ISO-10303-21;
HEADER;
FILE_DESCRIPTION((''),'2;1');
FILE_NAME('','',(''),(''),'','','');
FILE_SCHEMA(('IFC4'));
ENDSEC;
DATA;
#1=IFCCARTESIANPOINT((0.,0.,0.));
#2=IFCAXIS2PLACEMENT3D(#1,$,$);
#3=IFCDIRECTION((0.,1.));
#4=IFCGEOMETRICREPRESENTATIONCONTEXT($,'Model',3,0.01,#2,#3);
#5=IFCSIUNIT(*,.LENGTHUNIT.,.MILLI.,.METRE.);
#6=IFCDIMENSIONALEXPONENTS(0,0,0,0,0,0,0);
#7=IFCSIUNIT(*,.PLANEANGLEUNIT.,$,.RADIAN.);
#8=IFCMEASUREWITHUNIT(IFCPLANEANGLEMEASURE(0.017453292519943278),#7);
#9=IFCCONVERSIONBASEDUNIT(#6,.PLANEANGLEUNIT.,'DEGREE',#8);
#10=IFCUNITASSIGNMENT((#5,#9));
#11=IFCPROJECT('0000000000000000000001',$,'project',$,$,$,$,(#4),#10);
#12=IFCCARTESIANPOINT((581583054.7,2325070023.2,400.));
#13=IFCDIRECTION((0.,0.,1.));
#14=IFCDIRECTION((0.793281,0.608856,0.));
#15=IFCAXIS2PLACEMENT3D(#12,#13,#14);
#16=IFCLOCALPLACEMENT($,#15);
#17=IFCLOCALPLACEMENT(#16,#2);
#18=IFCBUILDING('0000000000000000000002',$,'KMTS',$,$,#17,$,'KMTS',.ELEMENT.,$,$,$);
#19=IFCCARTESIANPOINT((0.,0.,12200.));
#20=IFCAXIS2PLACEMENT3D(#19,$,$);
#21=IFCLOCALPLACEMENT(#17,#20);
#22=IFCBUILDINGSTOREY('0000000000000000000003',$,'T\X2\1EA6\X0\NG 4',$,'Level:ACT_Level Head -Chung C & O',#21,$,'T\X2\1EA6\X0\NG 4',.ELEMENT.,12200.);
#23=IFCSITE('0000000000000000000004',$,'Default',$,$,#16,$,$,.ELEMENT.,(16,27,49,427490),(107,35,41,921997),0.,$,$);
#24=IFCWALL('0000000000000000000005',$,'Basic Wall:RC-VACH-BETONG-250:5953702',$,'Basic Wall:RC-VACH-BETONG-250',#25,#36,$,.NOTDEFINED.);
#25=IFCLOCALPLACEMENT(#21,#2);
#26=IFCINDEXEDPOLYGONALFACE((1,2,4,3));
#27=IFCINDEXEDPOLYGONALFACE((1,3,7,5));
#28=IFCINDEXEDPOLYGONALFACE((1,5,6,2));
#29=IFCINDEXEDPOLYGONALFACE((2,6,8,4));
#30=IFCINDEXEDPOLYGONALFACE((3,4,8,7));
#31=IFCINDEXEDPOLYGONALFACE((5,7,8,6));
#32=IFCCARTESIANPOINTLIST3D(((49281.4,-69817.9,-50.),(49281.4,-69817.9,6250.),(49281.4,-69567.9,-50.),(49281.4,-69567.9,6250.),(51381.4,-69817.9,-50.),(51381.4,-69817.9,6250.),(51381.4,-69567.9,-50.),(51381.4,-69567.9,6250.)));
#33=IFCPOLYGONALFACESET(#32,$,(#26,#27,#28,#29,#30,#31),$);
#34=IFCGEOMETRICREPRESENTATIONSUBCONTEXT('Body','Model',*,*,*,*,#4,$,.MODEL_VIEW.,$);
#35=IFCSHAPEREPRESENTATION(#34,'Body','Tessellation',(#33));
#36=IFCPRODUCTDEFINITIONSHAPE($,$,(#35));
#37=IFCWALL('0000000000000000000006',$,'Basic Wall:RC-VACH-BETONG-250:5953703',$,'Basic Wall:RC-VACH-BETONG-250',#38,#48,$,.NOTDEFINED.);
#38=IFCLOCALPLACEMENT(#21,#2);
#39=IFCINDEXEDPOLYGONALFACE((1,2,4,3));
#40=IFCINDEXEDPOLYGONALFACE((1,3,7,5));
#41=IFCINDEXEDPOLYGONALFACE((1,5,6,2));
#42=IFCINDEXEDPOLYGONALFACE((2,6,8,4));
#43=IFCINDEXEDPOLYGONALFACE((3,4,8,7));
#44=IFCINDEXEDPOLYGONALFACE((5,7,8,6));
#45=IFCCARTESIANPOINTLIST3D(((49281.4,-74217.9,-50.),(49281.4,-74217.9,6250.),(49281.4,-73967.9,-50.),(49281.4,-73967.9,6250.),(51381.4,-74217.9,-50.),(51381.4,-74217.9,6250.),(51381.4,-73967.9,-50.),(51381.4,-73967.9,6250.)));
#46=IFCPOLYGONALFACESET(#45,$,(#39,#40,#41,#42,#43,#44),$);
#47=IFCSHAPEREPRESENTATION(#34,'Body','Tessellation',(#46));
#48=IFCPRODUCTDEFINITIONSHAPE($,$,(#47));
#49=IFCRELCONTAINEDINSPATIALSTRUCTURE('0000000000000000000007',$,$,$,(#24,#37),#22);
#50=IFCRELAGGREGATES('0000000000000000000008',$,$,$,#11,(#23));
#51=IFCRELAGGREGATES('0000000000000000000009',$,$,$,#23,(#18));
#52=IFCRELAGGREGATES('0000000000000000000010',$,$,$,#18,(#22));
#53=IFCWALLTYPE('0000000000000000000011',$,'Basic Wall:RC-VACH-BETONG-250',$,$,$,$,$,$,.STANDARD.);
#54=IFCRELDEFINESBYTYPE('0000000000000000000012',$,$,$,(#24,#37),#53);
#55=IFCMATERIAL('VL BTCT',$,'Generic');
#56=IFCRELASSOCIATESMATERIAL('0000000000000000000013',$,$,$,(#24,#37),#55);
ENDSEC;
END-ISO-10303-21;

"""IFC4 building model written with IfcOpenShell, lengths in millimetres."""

from ifc_helpers import new_model, entity, si_unit, converted_unit, direction, frame, origin, place, context, subcontext, project, spatial, indexed_curve, outline, extrude, material, type_object, element, save


model = new_model("IFC4")

# Units and contexts
model_context = context("Model", 3, precision=0.01, world=origin(), true_north=direction((0.0, 1.0)))
body_context = subcontext(model_context, "Body", "Model", "MODEL_VIEW")
ifc_project = project(units=[si_unit("LENGTHUNIT", "METRE", prefix="MILLI"), converted_unit("PLANEANGLEUNIT", "DEGREE", entity("IfcPlaneAngleMeasure", 0.017453292519943278), si_unit("PLANEANGLEUNIT", "RADIAN"), dimensions=[0, 0, 0, 0, 0, 0, 0])], contexts=[model_context])

# Site, building, storey
site_placement = place(None, frame((581583054.7, 2325070023.2, 400.0), z_axis=(0.0, 0.0, 1.0), x_axis=(0.793281, 0.608856, 0.0)))
site = spatial("IfcSite", under=ifc_project, at=site_placement, Name="Default", CompositionType="ELEMENT", RefLatitude=(16, 27, 49, 427490), RefLongitude=(107, 35, 41, 921997), RefElevation=0.0)
building_placement = place(site_placement, origin())
building = spatial("IfcBuilding", under=site, at=building_placement, Name="KMTS", LongName="KMTS", CompositionType="ELEMENT")
storey_placement = place(building_placement, frame((0.0, 0.0, 12200.0)))
storey = spatial("IfcBuildingStorey", under=building, at=storey_placement, Name="TẦNG 4", ObjectType="Level:ACT_Level Head -Chung C & O", LongName="TẦNG 4", CompositionType="ELEMENT", Elevation=12200.0)

# Shared definitions
ifc_material_1 = material(Name="VL BTCT", Category="Generic")

# Walls
wall_type_1 = type_object("IfcWallType", Name="Basic Wall:RC-VACH-BETONG-250", PredefinedType="STANDARD")
for number, where, z_axis, x_axis, name in (
    (1, (51381.4, -69692.9, -50.0), (0.0, 0.0, 1.0), (-1.0, 0.0, 0.0), "Basic Wall:RC-VACH-BETONG-250:5953702"),
    (2, (51381.4, -74092.9, -50.0), (0.0, 0.0, 1.0), (-1.0, 0.0, 0.0), "Basic Wall:RC-VACH-BETONG-250:5953703"),
):
    element("IfcWall", number, at=place(storey_placement, frame(where, z_axis=z_axis, x_axis=x_axis)), inside=storey, type_object=wall_type_1, material=ifc_material_1, Name=name, ObjectType="Basic Wall:RC-VACH-BETONG-250", PredefinedType="NOTDEFINED", context=body_context, shape_type="SweptSolid", body=[
        extrude(outline(indexed_curve([(2100.0, 125.0), (0.0, 125.0), (0.0, -125.0), (2100.0, -125.0), (2100.0, 125.0)], self_intersect=False)), origin(), (0.0, 0.0, 1.0), 6300.0),
    ])

save(model, "model.ifc")
